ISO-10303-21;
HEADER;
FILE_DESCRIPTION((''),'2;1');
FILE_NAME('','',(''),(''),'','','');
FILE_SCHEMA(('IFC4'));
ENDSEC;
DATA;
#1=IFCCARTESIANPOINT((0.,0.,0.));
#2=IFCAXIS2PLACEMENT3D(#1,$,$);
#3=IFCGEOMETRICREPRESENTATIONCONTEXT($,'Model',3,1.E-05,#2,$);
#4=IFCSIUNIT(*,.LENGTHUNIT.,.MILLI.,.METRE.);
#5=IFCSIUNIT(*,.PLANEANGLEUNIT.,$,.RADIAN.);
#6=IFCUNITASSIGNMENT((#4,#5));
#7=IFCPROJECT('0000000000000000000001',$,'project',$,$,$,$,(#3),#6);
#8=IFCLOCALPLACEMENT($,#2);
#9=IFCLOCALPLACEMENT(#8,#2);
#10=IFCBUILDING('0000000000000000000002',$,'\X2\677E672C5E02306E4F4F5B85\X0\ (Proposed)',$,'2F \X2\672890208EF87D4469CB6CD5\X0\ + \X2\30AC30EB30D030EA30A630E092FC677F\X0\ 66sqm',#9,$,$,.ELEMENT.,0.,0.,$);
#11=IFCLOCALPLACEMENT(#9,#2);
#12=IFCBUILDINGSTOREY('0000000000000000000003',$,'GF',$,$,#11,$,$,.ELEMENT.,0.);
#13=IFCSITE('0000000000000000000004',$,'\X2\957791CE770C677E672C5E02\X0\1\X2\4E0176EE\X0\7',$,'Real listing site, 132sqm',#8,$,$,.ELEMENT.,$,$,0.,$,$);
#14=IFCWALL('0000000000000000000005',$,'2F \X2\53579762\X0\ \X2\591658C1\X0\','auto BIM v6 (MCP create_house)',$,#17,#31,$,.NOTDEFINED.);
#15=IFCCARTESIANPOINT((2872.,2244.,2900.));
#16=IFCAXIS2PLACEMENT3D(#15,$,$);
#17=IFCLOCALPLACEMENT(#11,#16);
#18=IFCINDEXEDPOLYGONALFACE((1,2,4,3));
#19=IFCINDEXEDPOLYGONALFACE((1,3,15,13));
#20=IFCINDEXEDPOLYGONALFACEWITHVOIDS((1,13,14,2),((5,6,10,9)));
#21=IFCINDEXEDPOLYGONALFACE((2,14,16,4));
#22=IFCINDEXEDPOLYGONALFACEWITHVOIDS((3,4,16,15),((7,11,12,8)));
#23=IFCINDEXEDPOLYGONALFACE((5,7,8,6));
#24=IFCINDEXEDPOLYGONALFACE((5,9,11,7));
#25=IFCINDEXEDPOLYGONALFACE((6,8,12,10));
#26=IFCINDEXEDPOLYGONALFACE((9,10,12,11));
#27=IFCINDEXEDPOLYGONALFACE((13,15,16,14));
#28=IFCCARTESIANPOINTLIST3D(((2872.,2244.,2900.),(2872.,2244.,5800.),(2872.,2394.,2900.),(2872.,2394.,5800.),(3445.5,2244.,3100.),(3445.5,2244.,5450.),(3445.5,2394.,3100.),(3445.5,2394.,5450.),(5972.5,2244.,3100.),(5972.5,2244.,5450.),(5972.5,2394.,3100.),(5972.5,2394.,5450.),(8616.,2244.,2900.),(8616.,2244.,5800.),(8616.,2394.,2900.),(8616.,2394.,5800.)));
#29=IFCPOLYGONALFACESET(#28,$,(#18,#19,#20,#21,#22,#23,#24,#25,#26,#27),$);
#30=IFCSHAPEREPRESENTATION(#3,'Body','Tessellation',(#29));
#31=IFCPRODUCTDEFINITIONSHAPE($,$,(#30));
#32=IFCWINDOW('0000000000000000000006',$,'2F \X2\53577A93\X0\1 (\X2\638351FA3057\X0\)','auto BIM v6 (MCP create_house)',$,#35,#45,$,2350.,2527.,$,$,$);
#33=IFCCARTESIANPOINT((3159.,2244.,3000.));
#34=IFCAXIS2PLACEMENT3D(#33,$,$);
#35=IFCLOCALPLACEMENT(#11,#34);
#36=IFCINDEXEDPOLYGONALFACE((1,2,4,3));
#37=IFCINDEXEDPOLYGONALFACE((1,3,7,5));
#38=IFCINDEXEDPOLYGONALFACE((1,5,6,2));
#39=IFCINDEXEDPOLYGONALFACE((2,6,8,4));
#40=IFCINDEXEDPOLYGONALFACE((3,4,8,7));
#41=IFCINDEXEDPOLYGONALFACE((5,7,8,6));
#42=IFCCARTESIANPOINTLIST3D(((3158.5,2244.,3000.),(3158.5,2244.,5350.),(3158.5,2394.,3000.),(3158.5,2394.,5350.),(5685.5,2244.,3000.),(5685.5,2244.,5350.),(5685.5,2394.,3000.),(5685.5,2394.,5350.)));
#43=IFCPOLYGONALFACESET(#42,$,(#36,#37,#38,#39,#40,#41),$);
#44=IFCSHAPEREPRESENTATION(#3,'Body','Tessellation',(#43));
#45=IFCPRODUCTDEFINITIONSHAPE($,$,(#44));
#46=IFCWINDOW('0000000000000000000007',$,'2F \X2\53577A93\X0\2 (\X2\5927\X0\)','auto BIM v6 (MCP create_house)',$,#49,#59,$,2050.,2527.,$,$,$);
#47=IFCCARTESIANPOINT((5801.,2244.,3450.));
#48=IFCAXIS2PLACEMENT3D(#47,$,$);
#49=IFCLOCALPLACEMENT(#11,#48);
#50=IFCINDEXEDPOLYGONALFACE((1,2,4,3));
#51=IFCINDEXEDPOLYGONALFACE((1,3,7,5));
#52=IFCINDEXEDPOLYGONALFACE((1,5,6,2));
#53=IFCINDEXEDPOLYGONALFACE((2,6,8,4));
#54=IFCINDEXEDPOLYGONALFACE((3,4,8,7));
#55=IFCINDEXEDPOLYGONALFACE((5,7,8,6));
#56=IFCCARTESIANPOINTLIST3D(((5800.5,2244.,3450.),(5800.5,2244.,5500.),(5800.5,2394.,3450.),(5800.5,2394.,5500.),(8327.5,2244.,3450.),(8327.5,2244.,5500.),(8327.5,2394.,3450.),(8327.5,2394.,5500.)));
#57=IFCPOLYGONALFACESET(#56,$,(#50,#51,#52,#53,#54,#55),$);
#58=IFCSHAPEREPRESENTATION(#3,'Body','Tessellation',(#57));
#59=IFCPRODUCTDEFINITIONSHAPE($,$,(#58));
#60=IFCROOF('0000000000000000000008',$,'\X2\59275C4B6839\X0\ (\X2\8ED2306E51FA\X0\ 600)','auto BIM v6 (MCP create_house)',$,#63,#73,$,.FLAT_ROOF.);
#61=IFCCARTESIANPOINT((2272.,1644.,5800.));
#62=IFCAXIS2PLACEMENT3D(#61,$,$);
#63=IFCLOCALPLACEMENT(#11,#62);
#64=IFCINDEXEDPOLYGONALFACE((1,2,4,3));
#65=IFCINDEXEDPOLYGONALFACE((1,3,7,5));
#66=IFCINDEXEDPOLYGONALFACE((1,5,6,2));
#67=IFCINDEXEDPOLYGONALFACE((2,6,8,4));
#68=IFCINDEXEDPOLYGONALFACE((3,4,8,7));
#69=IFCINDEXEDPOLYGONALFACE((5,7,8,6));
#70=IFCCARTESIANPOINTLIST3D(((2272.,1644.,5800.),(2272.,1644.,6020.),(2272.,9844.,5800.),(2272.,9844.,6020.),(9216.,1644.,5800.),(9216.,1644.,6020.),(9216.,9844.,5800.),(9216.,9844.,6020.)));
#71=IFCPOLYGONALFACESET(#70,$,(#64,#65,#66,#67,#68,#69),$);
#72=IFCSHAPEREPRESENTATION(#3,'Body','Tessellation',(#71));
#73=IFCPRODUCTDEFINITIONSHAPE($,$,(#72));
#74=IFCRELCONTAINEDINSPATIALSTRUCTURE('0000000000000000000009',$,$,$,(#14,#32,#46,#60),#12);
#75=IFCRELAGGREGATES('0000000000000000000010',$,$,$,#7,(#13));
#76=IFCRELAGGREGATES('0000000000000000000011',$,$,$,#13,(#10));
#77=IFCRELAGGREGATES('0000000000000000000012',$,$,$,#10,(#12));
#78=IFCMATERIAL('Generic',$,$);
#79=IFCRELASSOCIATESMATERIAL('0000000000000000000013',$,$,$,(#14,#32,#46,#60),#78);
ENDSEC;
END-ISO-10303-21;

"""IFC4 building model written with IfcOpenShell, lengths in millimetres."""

from ifc_helpers import new_model, si_unit, frame, frame_2d, origin, place, context, project, spatial, rectangle, extrude, material, element, fill, save


model = new_model("IFC4")

# Units and contexts
model_context = context("Model", 3, precision=1e-05, world=origin())
ifc_project = project(units=[si_unit("LENGTHUNIT", "METRE", prefix="MILLI"), si_unit("PLANEANGLEUNIT", "RADIAN")], contexts=[model_context])

# Site, building, storey
site_placement = place(None, origin())
site = spatial("IfcSite", under=ifc_project, at=site_placement, Name="長野県松本市1丁目7", ObjectType="Real listing site, 132sqm", CompositionType="ELEMENT", RefElevation=0.0)
building_placement = place(site_placement, origin())
building = spatial("IfcBuilding", under=site, at=building_placement, Name="松本市の住宅 (Proposed)", ObjectType="2F 木造軸組構法 + ガルバリウム鋼板 66sqm", CompositionType="ELEMENT", ElevationOfRefHeight=0.0, ElevationOfTerrain=0.0)
storey_placement = place(building_placement, origin())
storey = spatial("IfcBuildingStorey", under=building, at=storey_placement, Name="GF", CompositionType="ELEMENT", Elevation=0.0)

# Shared definitions
ifc_material = material(Name="Generic")

# Wall, openings, windows
wall_1_placement = place(storey_placement, frame((2872.0, 2244.0, 2900.0)))
wall_1 = element("IfcWall", 1, at=wall_1_placement, inside=storey, material=ifc_material, Name="2F 南面 外壁", Description="auto BIM v6 (MCP create_house)", PredefinedType="NOTDEFINED", context=model_context, shape_type="SweptSolid", body=[
    extrude(rectangle(XDim=5744.0, YDim=150.0, at=frame_2d((2872.0, 75.0))), frame((2872.0, 2244.0, 2900.0)), (0.0, 0.0, 1.0), 2900.0),
])
opening_1_placement = place(storey_placement, frame((3159.0, 2244.0, 3000.0)))
opening_1 = element("IfcOpeningElement", 2, at=opening_1_placement, cuts=wall_1, PredefinedType="NOTDEFINED", context=model_context, shape_type="SweptSolid", body=[
    extrude(rectangle(XDim=2527.0, YDim=150.0, at=frame_2d((1263.0, 75.0))), frame((3159.0, 2244.0, 3000.0)), (0.0, 0.0, 1.0), 2350.0),
])
opening_2_placement = place(storey_placement, frame((5801.0, 2244.0, 3450.0)))
opening_2 = element("IfcOpeningElement", 3, at=opening_2_placement, cuts=wall_1, PredefinedType="NOTDEFINED", context=model_context, shape_type="SweptSolid", body=[
    extrude(rectangle(XDim=2527.0, YDim=150.0, at=frame_2d((1263.0, 75.0))), frame((5801.0, 2244.0, 3450.0)), (0.0, 0.0, 1.0), 2050.0),
])
window_1_placement = place(storey_placement, frame((3159.0, 2244.0, 3000.0)))
window_1 = element("IfcWindow", 4, at=window_1_placement, inside=storey, material=ifc_material, Name="2F 南窓1 (掃出し)", Description="auto BIM v6 (MCP create_house)", OverallHeight=2350.0, OverallWidth=2527.0, context=model_context, shape_type="SweptSolid", body=[
    extrude(rectangle(XDim=2527.0, YDim=150.0, at=frame_2d((1263.0, 75.0))), frame((3159.0, 2244.0, 3000.0)), (0.0, 0.0, 1.0), 2350.0),
])
fill(opening_1, window_1)
window_2_placement = place(storey_placement, frame((5801.0, 2244.0, 3450.0)))
window_2 = element("IfcWindow", 5, at=window_2_placement, inside=storey, material=ifc_material, Name="2F 南窓2 (大)", Description="auto BIM v6 (MCP create_house)", OverallHeight=2050.0, OverallWidth=2527.0, context=model_context, shape_type="SweptSolid", body=[
    extrude(rectangle(XDim=2527.0, YDim=150.0, at=frame_2d((1263.0, 75.0))), frame((5801.0, 2244.0, 3450.0)), (0.0, 0.0, 1.0), 2050.0),
])
fill(opening_2, window_2)

# Roof
roof_placement = place(storey_placement, frame((2272.0, 1644.0, 5800.0)))
element("IfcRoof", 6, at=roof_placement, inside=storey, material=ifc_material, Name="大屋根 (軒の出 600)", Description="auto BIM v6 (MCP create_house)", PredefinedType="FLAT_ROOF", context=model_context, shape_type="SweptSolid", body=[
    extrude(rectangle(XDim=6944.0, YDim=8200.0, at=frame_2d((3472.0, 4100.0))), frame((2272.0, 1644.0, 5800.0)), (0.0, 0.0, 1.0), 220.0),
])

save(model, "model.ifc")
